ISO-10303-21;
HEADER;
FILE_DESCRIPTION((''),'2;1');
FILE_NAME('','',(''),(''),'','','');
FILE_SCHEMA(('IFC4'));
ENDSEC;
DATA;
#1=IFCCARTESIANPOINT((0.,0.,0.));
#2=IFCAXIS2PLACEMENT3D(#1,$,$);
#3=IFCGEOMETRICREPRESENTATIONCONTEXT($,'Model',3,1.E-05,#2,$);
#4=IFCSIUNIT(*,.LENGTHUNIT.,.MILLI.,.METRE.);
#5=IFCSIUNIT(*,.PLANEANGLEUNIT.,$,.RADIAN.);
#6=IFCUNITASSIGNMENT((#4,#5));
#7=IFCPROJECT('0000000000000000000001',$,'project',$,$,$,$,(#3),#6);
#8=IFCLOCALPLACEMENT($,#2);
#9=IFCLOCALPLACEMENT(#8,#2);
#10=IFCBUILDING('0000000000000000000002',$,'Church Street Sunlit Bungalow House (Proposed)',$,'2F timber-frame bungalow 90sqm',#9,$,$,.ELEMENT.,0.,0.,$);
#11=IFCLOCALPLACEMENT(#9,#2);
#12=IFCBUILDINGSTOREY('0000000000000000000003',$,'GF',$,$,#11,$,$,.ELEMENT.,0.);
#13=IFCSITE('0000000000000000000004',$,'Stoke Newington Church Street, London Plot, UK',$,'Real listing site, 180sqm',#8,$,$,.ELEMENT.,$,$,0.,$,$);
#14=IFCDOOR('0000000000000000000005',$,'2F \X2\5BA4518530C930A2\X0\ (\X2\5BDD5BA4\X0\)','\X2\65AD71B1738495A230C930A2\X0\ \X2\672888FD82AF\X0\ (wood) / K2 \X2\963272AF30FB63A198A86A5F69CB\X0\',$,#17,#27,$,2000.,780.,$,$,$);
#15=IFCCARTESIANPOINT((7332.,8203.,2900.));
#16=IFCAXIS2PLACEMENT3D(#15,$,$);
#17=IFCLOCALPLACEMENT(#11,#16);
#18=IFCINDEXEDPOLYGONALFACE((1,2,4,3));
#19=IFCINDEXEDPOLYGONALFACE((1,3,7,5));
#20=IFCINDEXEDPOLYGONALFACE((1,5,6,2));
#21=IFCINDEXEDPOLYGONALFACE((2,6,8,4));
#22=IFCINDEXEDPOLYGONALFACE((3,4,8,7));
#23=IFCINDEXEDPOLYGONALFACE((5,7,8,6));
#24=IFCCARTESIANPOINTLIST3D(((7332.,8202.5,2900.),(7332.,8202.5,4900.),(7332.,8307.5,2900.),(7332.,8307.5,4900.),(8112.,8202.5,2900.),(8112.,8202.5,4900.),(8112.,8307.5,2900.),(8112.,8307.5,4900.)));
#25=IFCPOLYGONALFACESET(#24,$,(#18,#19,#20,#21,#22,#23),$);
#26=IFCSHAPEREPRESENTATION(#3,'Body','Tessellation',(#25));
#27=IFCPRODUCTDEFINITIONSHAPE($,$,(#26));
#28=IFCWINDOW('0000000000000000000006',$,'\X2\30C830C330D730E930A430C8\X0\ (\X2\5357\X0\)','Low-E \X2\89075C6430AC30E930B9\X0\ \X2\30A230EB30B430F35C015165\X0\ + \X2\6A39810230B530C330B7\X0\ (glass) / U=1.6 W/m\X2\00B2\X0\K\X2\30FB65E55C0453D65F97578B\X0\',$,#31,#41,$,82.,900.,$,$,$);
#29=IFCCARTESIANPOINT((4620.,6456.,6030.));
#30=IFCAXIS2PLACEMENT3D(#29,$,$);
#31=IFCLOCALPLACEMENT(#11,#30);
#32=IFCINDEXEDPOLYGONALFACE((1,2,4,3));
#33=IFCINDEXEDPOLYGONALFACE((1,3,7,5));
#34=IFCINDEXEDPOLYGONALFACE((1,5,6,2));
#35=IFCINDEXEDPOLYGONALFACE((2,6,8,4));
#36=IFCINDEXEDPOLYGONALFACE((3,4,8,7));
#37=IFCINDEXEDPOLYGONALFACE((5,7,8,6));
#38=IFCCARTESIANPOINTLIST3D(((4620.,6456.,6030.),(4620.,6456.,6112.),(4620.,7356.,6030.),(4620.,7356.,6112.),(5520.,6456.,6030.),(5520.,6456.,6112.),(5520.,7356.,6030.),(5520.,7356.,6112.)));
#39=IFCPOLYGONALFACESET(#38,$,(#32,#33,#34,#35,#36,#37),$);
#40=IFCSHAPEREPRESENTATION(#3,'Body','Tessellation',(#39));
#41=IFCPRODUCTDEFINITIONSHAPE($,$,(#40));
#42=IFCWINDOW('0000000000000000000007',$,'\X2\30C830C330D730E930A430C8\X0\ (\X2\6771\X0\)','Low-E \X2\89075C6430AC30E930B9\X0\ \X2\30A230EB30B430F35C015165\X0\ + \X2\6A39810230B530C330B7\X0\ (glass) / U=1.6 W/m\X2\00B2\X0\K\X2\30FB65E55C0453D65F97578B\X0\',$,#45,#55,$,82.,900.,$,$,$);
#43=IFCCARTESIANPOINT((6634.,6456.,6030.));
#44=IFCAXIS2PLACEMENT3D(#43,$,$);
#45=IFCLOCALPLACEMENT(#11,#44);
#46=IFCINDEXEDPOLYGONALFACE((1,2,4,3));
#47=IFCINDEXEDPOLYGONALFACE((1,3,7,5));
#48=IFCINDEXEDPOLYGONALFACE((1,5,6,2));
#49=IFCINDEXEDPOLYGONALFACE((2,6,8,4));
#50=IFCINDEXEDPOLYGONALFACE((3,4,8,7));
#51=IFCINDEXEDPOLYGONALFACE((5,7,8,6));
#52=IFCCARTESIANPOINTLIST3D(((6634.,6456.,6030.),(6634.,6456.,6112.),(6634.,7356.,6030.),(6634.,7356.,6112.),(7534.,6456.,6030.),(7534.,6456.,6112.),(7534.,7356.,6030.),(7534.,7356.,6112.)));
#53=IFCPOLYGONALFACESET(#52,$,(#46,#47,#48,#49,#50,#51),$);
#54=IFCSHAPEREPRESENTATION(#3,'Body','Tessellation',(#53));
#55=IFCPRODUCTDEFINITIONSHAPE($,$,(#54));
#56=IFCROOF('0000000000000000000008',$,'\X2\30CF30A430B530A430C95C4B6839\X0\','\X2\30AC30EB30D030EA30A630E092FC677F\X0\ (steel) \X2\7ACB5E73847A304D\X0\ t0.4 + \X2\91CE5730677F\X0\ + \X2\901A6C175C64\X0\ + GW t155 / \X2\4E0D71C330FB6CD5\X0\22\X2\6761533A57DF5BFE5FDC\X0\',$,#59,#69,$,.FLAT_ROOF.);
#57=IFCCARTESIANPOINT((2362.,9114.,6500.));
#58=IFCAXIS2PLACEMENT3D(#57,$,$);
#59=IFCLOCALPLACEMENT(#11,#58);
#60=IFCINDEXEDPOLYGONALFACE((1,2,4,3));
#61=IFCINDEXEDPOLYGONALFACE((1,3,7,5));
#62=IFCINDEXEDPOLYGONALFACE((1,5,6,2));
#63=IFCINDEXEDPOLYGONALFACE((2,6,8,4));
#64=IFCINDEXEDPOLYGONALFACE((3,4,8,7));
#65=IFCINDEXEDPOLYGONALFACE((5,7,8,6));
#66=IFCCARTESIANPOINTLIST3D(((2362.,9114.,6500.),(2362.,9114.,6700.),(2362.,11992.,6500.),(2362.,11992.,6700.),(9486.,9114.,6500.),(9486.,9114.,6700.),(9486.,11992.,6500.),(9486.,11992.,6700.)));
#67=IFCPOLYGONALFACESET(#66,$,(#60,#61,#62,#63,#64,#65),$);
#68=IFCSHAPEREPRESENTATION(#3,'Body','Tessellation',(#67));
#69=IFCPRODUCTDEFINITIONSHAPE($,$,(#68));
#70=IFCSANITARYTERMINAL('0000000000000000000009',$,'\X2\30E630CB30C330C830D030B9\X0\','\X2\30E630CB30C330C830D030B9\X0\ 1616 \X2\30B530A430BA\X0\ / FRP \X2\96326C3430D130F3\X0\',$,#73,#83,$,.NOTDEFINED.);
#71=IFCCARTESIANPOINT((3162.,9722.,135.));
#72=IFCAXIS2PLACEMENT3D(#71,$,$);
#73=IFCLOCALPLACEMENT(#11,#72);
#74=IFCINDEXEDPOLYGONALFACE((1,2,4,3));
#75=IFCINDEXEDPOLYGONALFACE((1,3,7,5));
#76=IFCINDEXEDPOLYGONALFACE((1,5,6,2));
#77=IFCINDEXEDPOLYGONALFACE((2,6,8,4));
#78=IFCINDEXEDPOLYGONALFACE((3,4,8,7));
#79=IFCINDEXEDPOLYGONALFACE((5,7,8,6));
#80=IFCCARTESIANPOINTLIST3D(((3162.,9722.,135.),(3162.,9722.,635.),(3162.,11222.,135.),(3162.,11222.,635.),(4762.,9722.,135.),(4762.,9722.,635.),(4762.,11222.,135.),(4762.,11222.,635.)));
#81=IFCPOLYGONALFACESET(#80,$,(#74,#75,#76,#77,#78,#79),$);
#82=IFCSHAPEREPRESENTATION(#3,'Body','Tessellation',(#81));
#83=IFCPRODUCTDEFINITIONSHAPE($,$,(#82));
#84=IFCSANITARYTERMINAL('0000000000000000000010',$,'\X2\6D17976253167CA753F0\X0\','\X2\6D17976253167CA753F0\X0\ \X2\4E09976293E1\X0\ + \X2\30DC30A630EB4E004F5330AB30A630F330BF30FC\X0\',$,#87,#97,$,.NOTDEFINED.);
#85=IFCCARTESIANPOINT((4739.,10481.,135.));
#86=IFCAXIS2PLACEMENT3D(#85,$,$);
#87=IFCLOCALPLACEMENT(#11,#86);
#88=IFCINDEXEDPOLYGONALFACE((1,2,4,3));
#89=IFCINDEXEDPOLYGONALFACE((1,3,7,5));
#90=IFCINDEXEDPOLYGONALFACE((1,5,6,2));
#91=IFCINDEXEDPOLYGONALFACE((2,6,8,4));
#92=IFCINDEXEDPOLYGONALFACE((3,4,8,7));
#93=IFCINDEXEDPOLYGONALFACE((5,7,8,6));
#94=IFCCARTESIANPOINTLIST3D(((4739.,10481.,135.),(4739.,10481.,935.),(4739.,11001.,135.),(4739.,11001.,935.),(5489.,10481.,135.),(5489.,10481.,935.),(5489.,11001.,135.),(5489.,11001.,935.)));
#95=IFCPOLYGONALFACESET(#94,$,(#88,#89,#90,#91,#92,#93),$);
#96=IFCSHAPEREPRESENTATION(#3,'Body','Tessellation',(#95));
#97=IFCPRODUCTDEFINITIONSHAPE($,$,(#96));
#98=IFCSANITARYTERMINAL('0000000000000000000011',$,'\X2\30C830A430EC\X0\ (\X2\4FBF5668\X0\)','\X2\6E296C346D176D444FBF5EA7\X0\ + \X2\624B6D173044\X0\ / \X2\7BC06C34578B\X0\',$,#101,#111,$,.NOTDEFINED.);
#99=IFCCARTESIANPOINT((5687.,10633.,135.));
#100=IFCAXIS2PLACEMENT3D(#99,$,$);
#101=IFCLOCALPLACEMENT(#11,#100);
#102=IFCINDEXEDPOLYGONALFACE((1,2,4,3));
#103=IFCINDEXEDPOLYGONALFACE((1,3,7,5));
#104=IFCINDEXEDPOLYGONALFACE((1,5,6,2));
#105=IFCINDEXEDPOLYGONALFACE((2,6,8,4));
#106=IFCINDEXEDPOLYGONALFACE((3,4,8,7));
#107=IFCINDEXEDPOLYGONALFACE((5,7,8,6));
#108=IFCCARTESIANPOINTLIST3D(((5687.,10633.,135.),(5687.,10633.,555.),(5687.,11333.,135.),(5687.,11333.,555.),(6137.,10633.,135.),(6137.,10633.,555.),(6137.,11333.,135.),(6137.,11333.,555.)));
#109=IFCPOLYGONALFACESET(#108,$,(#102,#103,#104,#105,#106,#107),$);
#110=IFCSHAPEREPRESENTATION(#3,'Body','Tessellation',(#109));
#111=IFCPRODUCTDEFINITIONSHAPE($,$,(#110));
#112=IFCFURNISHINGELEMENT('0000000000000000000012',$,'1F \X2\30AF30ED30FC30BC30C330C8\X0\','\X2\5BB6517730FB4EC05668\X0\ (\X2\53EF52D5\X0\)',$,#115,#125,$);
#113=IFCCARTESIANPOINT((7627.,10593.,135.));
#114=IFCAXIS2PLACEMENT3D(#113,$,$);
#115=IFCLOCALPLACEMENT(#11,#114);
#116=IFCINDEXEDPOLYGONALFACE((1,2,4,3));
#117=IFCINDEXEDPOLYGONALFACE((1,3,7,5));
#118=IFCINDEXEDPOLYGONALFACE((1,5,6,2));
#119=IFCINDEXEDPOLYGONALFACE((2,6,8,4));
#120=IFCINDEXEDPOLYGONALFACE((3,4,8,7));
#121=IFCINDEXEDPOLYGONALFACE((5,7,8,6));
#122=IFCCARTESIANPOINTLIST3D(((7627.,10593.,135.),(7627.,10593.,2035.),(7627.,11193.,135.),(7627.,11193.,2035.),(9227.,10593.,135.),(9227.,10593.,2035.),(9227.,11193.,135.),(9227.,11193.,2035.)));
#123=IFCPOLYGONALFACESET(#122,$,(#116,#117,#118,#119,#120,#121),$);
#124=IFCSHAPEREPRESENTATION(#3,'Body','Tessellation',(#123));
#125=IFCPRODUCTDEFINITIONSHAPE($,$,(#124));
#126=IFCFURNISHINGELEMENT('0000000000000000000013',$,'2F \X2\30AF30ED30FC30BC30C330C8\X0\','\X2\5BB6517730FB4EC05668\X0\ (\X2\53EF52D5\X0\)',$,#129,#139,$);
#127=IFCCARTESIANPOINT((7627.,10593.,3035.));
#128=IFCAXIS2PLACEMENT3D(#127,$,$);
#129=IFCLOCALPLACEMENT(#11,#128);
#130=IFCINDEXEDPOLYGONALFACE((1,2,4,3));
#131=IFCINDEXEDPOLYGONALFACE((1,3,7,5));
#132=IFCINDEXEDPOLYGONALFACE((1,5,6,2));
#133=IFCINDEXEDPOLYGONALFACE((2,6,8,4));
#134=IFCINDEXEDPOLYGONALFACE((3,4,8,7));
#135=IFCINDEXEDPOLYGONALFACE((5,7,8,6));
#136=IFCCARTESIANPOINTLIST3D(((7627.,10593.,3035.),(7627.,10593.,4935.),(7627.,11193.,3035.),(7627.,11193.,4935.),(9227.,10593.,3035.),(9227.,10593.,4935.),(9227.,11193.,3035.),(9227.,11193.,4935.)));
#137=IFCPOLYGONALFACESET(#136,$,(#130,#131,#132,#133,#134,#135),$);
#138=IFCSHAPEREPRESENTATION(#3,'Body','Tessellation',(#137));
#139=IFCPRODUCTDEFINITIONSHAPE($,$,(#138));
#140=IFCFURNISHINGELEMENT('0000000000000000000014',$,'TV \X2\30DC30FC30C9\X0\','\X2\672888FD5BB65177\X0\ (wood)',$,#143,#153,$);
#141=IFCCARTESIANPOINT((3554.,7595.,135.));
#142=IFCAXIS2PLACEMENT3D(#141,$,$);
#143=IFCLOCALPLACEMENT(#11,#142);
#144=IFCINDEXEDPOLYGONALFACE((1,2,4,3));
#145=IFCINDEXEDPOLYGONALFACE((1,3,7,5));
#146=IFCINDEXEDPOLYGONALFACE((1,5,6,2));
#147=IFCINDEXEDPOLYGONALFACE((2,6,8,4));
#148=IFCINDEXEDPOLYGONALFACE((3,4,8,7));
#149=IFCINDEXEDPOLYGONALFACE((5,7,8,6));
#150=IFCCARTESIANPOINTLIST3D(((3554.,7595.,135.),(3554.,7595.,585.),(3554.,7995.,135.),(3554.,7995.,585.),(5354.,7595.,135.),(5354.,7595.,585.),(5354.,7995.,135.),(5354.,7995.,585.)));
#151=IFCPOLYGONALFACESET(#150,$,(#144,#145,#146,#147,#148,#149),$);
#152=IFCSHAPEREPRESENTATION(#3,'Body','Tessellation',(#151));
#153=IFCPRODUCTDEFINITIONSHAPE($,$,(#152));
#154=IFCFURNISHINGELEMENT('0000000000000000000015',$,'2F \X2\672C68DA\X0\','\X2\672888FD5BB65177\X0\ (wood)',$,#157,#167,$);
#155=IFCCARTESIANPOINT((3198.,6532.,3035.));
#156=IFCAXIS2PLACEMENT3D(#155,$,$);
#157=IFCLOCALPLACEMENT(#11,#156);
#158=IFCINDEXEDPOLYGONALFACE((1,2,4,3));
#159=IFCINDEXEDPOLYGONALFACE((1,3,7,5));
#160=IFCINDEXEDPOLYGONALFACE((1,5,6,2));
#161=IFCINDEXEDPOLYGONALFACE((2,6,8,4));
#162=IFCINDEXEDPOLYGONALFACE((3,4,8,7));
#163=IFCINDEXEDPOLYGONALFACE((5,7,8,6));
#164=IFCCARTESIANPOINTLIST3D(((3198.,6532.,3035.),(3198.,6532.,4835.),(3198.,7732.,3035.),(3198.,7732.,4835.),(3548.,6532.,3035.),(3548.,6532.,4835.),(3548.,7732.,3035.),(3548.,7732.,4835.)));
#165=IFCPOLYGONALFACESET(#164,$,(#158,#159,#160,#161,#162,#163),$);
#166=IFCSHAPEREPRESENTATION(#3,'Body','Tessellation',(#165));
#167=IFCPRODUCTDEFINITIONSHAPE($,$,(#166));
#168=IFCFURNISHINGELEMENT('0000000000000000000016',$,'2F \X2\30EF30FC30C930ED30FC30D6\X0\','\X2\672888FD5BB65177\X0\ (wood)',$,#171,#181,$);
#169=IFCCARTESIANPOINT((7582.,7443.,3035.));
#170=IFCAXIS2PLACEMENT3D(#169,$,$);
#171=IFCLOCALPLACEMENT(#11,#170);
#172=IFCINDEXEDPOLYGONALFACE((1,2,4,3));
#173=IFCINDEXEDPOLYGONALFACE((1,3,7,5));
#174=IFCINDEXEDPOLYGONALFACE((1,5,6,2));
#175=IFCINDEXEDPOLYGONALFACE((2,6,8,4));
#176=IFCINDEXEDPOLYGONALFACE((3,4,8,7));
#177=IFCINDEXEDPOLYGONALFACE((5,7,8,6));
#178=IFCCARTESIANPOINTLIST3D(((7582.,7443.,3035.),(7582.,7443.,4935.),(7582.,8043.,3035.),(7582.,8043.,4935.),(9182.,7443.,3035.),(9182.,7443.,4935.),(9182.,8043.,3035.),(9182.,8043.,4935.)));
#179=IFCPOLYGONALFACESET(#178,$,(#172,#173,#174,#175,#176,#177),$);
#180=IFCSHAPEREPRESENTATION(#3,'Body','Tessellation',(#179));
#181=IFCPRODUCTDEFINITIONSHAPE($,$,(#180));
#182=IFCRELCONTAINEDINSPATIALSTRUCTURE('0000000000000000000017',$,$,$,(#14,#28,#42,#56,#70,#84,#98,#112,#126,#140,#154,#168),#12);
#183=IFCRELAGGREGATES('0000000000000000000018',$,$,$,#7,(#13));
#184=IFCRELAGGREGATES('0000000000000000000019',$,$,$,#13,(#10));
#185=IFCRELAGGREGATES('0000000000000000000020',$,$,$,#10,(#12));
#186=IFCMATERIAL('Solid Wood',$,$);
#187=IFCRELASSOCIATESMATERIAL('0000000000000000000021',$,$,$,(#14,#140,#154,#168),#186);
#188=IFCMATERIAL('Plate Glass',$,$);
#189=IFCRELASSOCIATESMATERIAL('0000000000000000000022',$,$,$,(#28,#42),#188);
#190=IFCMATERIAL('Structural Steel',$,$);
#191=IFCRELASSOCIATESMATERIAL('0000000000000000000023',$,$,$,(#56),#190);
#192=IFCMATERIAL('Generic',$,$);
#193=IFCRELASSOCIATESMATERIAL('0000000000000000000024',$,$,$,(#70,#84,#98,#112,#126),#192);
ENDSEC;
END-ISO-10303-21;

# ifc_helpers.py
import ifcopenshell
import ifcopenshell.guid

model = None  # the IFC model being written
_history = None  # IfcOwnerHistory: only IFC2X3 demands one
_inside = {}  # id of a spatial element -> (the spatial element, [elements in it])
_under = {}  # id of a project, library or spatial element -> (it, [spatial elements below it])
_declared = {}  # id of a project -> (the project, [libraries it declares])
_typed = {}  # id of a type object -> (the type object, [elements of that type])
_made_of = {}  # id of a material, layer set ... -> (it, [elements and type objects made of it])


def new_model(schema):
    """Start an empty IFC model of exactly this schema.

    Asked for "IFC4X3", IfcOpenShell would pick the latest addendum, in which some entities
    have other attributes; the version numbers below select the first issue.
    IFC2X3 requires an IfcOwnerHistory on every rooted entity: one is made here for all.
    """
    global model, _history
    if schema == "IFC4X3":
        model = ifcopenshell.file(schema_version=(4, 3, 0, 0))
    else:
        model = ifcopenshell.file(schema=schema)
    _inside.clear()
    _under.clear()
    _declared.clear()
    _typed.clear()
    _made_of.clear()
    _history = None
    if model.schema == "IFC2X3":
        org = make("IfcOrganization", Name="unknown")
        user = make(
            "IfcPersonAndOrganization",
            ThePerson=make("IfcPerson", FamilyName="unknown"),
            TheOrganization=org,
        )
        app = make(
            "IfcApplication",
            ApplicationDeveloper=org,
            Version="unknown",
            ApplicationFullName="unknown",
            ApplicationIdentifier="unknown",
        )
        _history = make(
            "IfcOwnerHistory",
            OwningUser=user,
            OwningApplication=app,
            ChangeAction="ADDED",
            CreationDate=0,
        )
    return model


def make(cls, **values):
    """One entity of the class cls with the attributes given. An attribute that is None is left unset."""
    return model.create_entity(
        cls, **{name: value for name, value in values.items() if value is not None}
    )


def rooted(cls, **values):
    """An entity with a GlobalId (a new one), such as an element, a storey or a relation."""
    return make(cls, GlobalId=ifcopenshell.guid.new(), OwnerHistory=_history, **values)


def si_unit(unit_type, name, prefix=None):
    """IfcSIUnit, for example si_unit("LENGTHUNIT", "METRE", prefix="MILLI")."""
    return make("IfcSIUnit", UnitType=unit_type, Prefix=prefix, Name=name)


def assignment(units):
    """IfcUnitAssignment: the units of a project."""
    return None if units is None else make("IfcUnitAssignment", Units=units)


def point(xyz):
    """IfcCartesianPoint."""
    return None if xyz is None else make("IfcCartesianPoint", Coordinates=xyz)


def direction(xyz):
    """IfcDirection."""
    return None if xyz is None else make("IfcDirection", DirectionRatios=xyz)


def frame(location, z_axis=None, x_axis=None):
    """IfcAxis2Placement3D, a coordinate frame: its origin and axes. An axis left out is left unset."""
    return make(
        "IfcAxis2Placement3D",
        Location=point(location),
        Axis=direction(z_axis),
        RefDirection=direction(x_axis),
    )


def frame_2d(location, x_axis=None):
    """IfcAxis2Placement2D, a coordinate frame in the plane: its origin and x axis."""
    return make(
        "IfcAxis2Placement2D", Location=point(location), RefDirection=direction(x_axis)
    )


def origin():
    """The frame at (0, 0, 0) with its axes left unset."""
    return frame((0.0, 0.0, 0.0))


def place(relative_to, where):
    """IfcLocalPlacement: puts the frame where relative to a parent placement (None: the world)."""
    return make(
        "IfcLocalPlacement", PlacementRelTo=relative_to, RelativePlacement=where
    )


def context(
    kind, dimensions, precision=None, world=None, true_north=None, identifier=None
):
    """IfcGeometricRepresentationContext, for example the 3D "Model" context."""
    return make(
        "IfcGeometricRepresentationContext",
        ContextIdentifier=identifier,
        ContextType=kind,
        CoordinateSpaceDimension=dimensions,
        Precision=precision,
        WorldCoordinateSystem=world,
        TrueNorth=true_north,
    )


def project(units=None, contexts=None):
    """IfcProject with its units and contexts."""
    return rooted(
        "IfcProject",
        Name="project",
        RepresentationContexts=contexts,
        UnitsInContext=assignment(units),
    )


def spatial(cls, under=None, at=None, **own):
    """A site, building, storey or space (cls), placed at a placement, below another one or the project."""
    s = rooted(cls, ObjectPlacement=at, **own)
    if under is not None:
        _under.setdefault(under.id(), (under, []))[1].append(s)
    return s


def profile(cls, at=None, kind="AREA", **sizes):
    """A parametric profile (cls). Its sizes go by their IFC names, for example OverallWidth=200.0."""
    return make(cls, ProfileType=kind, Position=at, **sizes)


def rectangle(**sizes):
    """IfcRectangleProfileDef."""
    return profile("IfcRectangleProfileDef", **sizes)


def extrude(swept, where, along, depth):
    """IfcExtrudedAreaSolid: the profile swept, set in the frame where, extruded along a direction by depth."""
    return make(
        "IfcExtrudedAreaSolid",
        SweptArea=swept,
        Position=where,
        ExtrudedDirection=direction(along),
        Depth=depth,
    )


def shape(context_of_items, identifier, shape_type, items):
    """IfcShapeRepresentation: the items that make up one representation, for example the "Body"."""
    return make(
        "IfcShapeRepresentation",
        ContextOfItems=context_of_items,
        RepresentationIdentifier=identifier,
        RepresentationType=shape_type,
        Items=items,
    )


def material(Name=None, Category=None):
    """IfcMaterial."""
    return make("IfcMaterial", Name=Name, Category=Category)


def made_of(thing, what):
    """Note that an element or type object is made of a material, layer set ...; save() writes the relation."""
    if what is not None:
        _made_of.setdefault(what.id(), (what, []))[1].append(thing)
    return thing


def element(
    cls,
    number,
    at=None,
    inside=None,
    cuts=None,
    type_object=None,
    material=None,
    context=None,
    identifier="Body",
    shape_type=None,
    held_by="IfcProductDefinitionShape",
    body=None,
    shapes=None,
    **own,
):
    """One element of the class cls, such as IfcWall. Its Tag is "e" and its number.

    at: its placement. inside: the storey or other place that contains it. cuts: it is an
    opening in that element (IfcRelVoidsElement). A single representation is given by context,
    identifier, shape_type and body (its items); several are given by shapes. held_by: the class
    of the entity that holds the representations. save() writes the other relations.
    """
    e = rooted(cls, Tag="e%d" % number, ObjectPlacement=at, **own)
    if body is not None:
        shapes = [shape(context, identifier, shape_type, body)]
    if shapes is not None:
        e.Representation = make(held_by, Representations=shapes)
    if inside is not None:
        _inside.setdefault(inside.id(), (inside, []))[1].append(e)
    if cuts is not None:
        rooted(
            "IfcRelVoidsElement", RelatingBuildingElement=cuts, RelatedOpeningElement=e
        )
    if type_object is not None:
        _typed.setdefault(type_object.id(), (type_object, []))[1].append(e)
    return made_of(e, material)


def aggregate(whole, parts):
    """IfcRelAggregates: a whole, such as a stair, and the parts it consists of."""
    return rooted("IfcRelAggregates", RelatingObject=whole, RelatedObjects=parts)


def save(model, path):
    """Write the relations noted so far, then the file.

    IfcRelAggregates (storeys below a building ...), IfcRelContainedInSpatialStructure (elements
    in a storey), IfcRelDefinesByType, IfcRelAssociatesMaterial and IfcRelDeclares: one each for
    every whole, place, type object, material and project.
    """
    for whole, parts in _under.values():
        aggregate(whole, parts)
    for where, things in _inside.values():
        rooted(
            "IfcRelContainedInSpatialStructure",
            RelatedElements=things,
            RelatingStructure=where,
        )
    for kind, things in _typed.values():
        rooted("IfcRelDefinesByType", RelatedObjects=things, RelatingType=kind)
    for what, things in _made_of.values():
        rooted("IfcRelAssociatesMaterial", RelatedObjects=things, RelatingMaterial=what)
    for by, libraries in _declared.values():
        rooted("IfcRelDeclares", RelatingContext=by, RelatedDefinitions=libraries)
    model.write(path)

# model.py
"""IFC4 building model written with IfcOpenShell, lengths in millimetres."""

from ifc_helpers import new_model, si_unit, frame, frame_2d, origin, place, context, project, spatial, rectangle, extrude, material, element, save


model = new_model("IFC4")

# Units and contexts
model_context = context("Model", 3, precision=1e-05, world=origin())
ifc_project = project(units=[si_unit("LENGTHUNIT", "METRE", prefix="MILLI"), si_unit("PLANEANGLEUNIT", "RADIAN")], contexts=[model_context])

# Site, building, storey
site_placement = place(None, origin())
site = spatial("IfcSite", under=ifc_project, at=site_placement, Name="Stoke Newington Church Street, London Plot, UK", ObjectType="Real listing site, 180sqm", CompositionType="ELEMENT", RefElevation=0.0)
building_placement = place(site_placement, origin())
building = spatial("IfcBuilding", under=site, at=building_placement, Name="Church Street Sunlit Bungalow House (Proposed)", ObjectType="2F timber-frame bungalow 90sqm", CompositionType="ELEMENT", ElevationOfRefHeight=0.0, ElevationOfTerrain=0.0)
storey_placement = place(building_placement, origin())
storey = spatial("IfcBuildingStorey", under=building, at=storey_placement, Name="GF", CompositionType="ELEMENT", Elevation=0.0)

# Shared definitions
ifc_material_1 = material(Name="Solid Wood")
ifc_material_2 = material(Name="Plate Glass")

# Door
door_1_placement = place(storey_placement, frame((7332.0, 8203.0, 2900.0)))
element("IfcDoor", 1, at=door_1_placement, inside=storey, material=ifc_material_1, Name="2F 室内ドア (寝室)", Description="断熱玄関ドア 木製芯 (wood) / K2 防犯・採風機構", OverallHeight=2000.0, OverallWidth=780.0, context=model_context, shape_type="SweptSolid", body=[
    extrude(rectangle(XDim=780.0, YDim=105.0, at=frame_2d((390.0, 52.0))), frame((7332.0, 8203.0, 2900.0)), (0.0, 0.0, 1.0), 2000.0),
])

# Windows
window_1_placement = place(storey_placement, frame((4620.0, 6456.0, 6030.0)))
element("IfcWindow", 2, at=window_1_placement, inside=storey, material=ifc_material_2, Name="トップライト (南)", Description="Low-E 複層ガラス アルゴン封入 + 樹脂サッシ (glass) / U=1.6 W/m²K・日射取得型", OverallHeight=82.0, OverallWidth=900.0, context=model_context, shape_type="SweptSolid", body=[
    extrude(rectangle(XDim=900.0, YDim=900.0, at=frame_2d((450.0, 450.0))), frame((4620.0, 6456.0, 6030.0)), (0.0, 0.0, 1.0), 82.0),
])
window_2_placement = place(storey_placement, frame((6634.0, 6456.0, 6030.0)))
element("IfcWindow", 3, at=window_2_placement, inside=storey, material=ifc_material_2, Name="トップライト (東)", Description="Low-E 複層ガラス アルゴン封入 + 樹脂サッシ (glass) / U=1.6 W/m²K・日射取得型", OverallHeight=82.0, OverallWidth=900.0, context=model_context, shape_type="SweptSolid", body=[
    extrude(rectangle(XDim=900.0, YDim=900.0, at=frame_2d((450.0, 450.0))), frame((6634.0, 6456.0, 6030.0)), (0.0, 0.0, 1.0), 82.0),
])

# Roof
ifc_material_3 = material(Name="Structural Steel")
roof_placement = place(storey_placement, frame((2362.0, 9114.0, 6500.0)))
element("IfcRoof", 4, at=roof_placement, inside=storey, material=ifc_material_3, Name="ハイサイド屋根", Description="ガルバリウム鋼板 (steel) 立平葺き t0.4 + 野地板 + 通気層 + GW t155 / 不燃・法22条区域対応", PredefinedType="FLAT_ROOF", context=model_context, shape_type="SweptSolid", body=[
    extrude(rectangle(XDim=7124.0, YDim=2878.0, at=frame_2d((3562.0, 1439.0))), frame((2362.0, 9114.0, 6500.0)), (0.0, 0.0, 1.0), 200.0),
])

# Sanitary terminals
ifc_material_4 = material(Name="Generic")
sanitary_terminal_1_placement = place(storey_placement, frame((3162.0, 9722.0, 135.0)))
element("IfcSanitaryTerminal", 5, at=sanitary_terminal_1_placement, inside=storey, material=ifc_material_4, Name="ユニットバス", Description="ユニットバス 1616 サイズ / FRP 防水パン", PredefinedType="NOTDEFINED", context=model_context, shape_type="SweptSolid", body=[
    extrude(rectangle(XDim=1600.0, YDim=1500.0, at=frame_2d((800.0, 750.0))), frame((3162.0, 9722.0, 135.0)), (0.0, 0.0, 1.0), 500.0),
])
sanitary_terminal_2_placement = place(storey_placement, frame((4739.0, 10481.0, 135.0)))
element("IfcSanitaryTerminal", 6, at=sanitary_terminal_2_placement, inside=storey, material=ifc_material_4, Name="洗面化粧台", Description="洗面化粧台 三面鏡 + ボウル一体カウンター", PredefinedType="NOTDEFINED", context=model_context, shape_type="SweptSolid", body=[
    extrude(rectangle(XDim=750.0, YDim=520.0, at=frame_2d((375.0, 260.0))), frame((4739.0, 10481.0, 135.0)), (0.0, 0.0, 1.0), 800.0),
])
sanitary_terminal_3_placement = place(storey_placement, frame((5687.0, 10633.0, 135.0)))
element("IfcSanitaryTerminal", 7, at=sanitary_terminal_3_placement, inside=storey, material=ifc_material_4, Name="トイレ (便器)", Description="温水洗浄便座 + 手洗い / 節水型", PredefinedType="NOTDEFINED", context=model_context, shape_type="SweptSolid", body=[
    extrude(rectangle(XDim=450.0, YDim=700.0, at=frame_2d((225.0, 350.0))), frame((5687.0, 10633.0, 135.0)), (0.0, 0.0, 1.0), 420.0),
])

# Furnishing elements
furnishing_1_placement = place(storey_placement, frame((7627.0, 10593.0, 135.0)))
element("IfcFurnishingElement", 8, at=furnishing_1_placement, inside=storey, material=ifc_material_4, Name="1F クローゼット", Description="家具・什器 (可動)", context=model_context, shape_type="SweptSolid", body=[
    extrude(rectangle(XDim=1600.0, YDim=600.0, at=frame_2d((800.0, 300.0))), frame((7627.0, 10593.0, 135.0)), (0.0, 0.0, 1.0), 1900.0),
])
furnishing_2_placement = place(storey_placement, frame((7627.0, 10593.0, 3035.0)))
element("IfcFurnishingElement", 9, at=furnishing_2_placement, inside=storey, material=ifc_material_4, Name="2F クローゼット", Description="家具・什器 (可動)", context=model_context, shape_type="SweptSolid", body=[
    extrude(rectangle(XDim=1600.0, YDim=600.0, at=frame_2d((800.0, 300.0))), frame((7627.0, 10593.0, 3035.0)), (0.0, 0.0, 1.0), 1900.0),
])
furnishing_3_placement = place(storey_placement, frame((3554.0, 7595.0, 135.0)))
element("IfcFurnishingElement", 10, at=furnishing_3_placement, inside=storey, material=ifc_material_1, Name="TV ボード", Description="木製家具 (wood)", context=model_context, shape_type="SweptSolid", body=[
    extrude(rectangle(XDim=1800.0, YDim=400.0, at=frame_2d((900.0, 200.0))), frame((3554.0, 7595.0, 135.0)), (0.0, 0.0, 1.0), 450.0),
])
furnishing_4_placement = place(storey_placement, frame((3198.0, 6532.0, 3035.0)))
element("IfcFurnishingElement", 11, at=furnishing_4_placement, inside=storey, material=ifc_material_1, Name="2F 本棚", Description="木製家具 (wood)", context=model_context, shape_type="SweptSolid", body=[
    extrude(rectangle(XDim=350.0, YDim=1200.0, at=frame_2d((175.0, 600.0))), frame((3198.0, 6532.0, 3035.0)), (0.0, 0.0, 1.0), 1800.0),
])
furnishing_5_placement = place(storey_placement, frame((7582.0, 7443.0, 3035.0)))
element("IfcFurnishingElement", 12, at=furnishing_5_placement, inside=storey, material=ifc_material_1, Name="2F ワードローブ", Description="木製家具 (wood)", context=model_context, shape_type="SweptSolid", body=[
    extrude(rectangle(XDim=1600.0, YDim=600.0, at=frame_2d((800.0, 300.0))), frame((7582.0, 7443.0, 3035.0)), (0.0, 0.0, 1.0), 1900.0),
])

save(model, "model.ifc")
